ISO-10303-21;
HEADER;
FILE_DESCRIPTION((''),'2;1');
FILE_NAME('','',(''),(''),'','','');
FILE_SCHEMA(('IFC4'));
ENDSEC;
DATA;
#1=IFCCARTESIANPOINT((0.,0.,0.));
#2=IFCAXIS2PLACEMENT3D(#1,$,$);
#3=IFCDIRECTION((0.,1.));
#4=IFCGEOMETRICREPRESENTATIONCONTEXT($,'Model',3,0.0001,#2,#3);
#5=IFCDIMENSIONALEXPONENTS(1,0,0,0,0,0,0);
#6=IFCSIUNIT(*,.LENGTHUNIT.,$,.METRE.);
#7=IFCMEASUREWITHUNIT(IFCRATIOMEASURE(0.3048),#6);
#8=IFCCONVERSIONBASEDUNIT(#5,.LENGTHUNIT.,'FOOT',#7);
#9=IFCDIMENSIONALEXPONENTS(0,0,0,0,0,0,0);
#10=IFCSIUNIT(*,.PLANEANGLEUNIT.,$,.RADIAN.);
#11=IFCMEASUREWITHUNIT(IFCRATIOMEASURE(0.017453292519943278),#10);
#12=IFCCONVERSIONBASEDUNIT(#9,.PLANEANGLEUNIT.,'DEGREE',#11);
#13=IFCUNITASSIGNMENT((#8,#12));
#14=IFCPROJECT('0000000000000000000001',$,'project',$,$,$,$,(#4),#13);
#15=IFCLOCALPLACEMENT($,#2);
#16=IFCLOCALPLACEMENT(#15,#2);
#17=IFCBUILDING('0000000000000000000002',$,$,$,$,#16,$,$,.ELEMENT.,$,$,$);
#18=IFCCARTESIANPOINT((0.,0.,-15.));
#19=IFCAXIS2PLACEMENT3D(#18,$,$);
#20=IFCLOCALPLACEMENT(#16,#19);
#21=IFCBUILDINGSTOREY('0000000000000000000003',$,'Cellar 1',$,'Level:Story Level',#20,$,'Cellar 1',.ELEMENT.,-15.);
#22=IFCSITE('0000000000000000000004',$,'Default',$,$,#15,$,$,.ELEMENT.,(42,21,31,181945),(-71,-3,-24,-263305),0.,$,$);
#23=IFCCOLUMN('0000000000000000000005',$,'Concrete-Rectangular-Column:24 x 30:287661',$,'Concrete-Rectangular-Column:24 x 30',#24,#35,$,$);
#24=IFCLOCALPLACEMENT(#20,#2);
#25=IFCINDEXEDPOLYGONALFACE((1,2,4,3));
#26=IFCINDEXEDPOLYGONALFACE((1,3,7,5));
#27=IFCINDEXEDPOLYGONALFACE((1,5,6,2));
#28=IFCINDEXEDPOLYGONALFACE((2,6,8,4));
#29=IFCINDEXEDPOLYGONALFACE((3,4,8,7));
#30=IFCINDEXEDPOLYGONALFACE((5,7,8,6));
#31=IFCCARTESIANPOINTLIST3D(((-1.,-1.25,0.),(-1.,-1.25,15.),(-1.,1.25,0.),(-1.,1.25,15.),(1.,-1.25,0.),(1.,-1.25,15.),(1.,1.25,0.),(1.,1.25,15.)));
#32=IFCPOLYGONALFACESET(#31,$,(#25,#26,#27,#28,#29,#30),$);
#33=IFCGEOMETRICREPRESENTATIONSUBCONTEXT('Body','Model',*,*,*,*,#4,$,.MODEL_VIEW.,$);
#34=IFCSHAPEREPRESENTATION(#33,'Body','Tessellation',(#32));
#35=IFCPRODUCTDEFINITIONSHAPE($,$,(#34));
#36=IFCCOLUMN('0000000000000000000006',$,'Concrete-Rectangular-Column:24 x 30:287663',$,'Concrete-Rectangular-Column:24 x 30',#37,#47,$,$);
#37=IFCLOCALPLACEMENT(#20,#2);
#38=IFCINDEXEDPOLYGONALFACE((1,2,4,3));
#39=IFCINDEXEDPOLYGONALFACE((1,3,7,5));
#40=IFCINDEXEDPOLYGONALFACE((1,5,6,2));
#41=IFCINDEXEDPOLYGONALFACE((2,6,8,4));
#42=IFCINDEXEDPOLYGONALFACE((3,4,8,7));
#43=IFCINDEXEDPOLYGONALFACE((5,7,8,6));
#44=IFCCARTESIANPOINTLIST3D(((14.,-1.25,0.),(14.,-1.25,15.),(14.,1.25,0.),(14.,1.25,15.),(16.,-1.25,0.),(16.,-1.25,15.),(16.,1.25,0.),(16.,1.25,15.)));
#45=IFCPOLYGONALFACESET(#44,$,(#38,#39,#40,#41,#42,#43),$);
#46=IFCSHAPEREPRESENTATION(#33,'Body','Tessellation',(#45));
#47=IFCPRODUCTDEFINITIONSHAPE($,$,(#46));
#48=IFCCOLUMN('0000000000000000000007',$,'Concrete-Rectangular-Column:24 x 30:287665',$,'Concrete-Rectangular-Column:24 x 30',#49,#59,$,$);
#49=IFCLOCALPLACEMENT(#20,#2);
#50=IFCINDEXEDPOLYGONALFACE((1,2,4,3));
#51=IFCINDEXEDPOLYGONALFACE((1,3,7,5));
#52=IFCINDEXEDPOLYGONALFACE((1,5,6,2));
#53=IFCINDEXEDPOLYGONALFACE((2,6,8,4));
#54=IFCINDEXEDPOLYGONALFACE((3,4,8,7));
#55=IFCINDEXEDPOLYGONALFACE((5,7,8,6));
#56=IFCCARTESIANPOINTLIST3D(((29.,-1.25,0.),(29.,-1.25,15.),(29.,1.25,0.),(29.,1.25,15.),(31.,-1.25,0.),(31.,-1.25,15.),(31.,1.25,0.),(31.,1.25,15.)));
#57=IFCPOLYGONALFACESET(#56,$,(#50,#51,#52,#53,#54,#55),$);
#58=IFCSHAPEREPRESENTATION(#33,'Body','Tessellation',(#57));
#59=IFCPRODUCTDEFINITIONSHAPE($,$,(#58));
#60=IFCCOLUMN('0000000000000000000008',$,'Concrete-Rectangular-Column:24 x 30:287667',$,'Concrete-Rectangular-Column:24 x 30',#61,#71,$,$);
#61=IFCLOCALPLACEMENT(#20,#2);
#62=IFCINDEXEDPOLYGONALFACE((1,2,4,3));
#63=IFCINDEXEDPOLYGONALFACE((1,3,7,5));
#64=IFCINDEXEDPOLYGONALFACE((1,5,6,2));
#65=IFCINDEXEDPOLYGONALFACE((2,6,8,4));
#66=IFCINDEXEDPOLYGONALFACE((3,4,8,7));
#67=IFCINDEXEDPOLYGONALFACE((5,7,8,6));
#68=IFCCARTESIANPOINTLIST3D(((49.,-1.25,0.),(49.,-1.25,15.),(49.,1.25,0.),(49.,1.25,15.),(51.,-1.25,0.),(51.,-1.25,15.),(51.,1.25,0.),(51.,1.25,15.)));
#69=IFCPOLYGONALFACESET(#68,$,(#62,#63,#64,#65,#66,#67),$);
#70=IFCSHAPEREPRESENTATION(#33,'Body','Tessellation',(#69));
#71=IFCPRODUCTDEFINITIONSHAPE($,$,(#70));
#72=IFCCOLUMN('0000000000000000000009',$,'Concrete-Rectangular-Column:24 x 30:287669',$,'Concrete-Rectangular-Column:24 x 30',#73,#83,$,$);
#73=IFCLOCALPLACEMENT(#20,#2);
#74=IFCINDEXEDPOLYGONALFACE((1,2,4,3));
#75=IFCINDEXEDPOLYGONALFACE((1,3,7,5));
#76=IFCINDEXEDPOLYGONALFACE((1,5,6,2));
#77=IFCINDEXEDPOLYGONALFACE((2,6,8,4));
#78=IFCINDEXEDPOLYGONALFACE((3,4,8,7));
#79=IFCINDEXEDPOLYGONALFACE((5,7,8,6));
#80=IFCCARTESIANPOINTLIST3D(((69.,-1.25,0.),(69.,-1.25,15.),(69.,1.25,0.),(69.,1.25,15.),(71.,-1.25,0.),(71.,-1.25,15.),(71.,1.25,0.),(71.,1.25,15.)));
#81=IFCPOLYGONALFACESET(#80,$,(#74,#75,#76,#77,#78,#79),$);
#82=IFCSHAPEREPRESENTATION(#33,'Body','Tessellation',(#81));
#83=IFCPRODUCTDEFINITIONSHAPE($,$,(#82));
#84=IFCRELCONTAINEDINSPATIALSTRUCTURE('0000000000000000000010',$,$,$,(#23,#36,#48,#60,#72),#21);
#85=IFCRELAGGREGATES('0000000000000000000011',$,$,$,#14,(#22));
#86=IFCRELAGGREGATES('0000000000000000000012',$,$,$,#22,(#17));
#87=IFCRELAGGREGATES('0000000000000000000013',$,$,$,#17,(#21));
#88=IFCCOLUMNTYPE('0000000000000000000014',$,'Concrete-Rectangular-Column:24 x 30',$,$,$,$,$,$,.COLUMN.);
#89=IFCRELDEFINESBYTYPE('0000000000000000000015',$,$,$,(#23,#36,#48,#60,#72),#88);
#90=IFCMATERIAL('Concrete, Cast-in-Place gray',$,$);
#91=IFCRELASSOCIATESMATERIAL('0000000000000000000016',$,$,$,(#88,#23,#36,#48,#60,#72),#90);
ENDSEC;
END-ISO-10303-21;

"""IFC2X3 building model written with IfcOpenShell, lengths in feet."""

from ifc_helpers import new_model, entity, si_unit, converted_unit, direction, frame, origin, origin_2d_with_axis, place, context, subcontext, project, spatial, rectangle, extrude, source, transform, mapped, material, type_object, type_shapes, element, save


model = new_model("IFC2X3")

# Units and contexts
model_context = context("Model", 3, precision=0.0001, world=origin(), true_north=direction((0.0, 1.0)))
body_context = subcontext(model_context, "Body", "Model", "MODEL_VIEW")
ifc_project = project(units=[converted_unit("LENGTHUNIT", "FOOT", entity("IfcRatioMeasure", 0.3048), si_unit("LENGTHUNIT", "METRE"), dimensions=[1, 0, 0, 0, 0, 0, 0]), converted_unit("PLANEANGLEUNIT", "DEGREE", entity("IfcRatioMeasure", 0.017453292519943278), si_unit("PLANEANGLEUNIT", "RADIAN"), dimensions=[0, 0, 0, 0, 0, 0, 0])], contexts=[model_context])

# Site, building, storey
site_placement = place(None, origin())
site = spatial("IfcSite", under=ifc_project, at=site_placement, Name="Default", CompositionType="ELEMENT", RefLatitude=(42, 21, 31, 181945), RefLongitude=(-71, -3, -24, -263305), RefElevation=0.0)
building_placement = place(site_placement, origin())
building = spatial("IfcBuilding", under=site, at=building_placement, CompositionType="ELEMENT")
storey_placement = place(building_placement, frame((0.0, 0.0, -15.0)))
storey = spatial("IfcBuildingStorey", under=building, at=storey_placement, Name="Cellar 1", ObjectType="Level:Story Level", LongName="Cellar 1", CompositionType="ELEMENT", Elevation=-15.0)

# Columns
ifc_material = material(Name="Concrete, Cast-in-Place gray")
column_type = type_object("IfcColumnType", Name="Concrete-Rectangular-Column:24 x 30", PredefinedType="COLUMN", material=ifc_material)
shared_shape = source(origin(), body_context, "Body", "SweptSolid", [
    extrude(rectangle(XDim=2.5, YDim=2.0, at=origin_2d_with_axis()), frame((0.0, 0.0, -15.0), z_axis=(0.0, 0.0, 1.0), x_axis=(0.0, -1.0, 0.0)), (0.0, 0.0, 1.0), 15.0),
])
type_shapes(column_type, [shared_shape])
for number, where, name in (
    (1, (0.0, 0.0, 15.0), "Concrete-Rectangular-Column:24 x 30:287661"),
    (2, (15.0, 0.0, 15.0), "Concrete-Rectangular-Column:24 x 30:287663"),
    (3, (30.0, 0.0, 15.0), "Concrete-Rectangular-Column:24 x 30:287665"),
    (4, (50.0, 0.0, 15.0), "Concrete-Rectangular-Column:24 x 30:287667"),
    (5, (70.0, 0.0, 15.0), "Concrete-Rectangular-Column:24 x 30:287669"),
):
    element("IfcColumn", number, at=place(storey_placement, frame(where)), inside=storey, type_object=column_type, material=ifc_material, Name=name, ObjectType="Concrete-Rectangular-Column:24 x 30", context=body_context, shape_type="MappedRepresentation", body=[
        mapped(shared_shape, transform((0.0, 0.0, 0.0), scale=1.0)),
    ])

save(model, "model.ifc")
